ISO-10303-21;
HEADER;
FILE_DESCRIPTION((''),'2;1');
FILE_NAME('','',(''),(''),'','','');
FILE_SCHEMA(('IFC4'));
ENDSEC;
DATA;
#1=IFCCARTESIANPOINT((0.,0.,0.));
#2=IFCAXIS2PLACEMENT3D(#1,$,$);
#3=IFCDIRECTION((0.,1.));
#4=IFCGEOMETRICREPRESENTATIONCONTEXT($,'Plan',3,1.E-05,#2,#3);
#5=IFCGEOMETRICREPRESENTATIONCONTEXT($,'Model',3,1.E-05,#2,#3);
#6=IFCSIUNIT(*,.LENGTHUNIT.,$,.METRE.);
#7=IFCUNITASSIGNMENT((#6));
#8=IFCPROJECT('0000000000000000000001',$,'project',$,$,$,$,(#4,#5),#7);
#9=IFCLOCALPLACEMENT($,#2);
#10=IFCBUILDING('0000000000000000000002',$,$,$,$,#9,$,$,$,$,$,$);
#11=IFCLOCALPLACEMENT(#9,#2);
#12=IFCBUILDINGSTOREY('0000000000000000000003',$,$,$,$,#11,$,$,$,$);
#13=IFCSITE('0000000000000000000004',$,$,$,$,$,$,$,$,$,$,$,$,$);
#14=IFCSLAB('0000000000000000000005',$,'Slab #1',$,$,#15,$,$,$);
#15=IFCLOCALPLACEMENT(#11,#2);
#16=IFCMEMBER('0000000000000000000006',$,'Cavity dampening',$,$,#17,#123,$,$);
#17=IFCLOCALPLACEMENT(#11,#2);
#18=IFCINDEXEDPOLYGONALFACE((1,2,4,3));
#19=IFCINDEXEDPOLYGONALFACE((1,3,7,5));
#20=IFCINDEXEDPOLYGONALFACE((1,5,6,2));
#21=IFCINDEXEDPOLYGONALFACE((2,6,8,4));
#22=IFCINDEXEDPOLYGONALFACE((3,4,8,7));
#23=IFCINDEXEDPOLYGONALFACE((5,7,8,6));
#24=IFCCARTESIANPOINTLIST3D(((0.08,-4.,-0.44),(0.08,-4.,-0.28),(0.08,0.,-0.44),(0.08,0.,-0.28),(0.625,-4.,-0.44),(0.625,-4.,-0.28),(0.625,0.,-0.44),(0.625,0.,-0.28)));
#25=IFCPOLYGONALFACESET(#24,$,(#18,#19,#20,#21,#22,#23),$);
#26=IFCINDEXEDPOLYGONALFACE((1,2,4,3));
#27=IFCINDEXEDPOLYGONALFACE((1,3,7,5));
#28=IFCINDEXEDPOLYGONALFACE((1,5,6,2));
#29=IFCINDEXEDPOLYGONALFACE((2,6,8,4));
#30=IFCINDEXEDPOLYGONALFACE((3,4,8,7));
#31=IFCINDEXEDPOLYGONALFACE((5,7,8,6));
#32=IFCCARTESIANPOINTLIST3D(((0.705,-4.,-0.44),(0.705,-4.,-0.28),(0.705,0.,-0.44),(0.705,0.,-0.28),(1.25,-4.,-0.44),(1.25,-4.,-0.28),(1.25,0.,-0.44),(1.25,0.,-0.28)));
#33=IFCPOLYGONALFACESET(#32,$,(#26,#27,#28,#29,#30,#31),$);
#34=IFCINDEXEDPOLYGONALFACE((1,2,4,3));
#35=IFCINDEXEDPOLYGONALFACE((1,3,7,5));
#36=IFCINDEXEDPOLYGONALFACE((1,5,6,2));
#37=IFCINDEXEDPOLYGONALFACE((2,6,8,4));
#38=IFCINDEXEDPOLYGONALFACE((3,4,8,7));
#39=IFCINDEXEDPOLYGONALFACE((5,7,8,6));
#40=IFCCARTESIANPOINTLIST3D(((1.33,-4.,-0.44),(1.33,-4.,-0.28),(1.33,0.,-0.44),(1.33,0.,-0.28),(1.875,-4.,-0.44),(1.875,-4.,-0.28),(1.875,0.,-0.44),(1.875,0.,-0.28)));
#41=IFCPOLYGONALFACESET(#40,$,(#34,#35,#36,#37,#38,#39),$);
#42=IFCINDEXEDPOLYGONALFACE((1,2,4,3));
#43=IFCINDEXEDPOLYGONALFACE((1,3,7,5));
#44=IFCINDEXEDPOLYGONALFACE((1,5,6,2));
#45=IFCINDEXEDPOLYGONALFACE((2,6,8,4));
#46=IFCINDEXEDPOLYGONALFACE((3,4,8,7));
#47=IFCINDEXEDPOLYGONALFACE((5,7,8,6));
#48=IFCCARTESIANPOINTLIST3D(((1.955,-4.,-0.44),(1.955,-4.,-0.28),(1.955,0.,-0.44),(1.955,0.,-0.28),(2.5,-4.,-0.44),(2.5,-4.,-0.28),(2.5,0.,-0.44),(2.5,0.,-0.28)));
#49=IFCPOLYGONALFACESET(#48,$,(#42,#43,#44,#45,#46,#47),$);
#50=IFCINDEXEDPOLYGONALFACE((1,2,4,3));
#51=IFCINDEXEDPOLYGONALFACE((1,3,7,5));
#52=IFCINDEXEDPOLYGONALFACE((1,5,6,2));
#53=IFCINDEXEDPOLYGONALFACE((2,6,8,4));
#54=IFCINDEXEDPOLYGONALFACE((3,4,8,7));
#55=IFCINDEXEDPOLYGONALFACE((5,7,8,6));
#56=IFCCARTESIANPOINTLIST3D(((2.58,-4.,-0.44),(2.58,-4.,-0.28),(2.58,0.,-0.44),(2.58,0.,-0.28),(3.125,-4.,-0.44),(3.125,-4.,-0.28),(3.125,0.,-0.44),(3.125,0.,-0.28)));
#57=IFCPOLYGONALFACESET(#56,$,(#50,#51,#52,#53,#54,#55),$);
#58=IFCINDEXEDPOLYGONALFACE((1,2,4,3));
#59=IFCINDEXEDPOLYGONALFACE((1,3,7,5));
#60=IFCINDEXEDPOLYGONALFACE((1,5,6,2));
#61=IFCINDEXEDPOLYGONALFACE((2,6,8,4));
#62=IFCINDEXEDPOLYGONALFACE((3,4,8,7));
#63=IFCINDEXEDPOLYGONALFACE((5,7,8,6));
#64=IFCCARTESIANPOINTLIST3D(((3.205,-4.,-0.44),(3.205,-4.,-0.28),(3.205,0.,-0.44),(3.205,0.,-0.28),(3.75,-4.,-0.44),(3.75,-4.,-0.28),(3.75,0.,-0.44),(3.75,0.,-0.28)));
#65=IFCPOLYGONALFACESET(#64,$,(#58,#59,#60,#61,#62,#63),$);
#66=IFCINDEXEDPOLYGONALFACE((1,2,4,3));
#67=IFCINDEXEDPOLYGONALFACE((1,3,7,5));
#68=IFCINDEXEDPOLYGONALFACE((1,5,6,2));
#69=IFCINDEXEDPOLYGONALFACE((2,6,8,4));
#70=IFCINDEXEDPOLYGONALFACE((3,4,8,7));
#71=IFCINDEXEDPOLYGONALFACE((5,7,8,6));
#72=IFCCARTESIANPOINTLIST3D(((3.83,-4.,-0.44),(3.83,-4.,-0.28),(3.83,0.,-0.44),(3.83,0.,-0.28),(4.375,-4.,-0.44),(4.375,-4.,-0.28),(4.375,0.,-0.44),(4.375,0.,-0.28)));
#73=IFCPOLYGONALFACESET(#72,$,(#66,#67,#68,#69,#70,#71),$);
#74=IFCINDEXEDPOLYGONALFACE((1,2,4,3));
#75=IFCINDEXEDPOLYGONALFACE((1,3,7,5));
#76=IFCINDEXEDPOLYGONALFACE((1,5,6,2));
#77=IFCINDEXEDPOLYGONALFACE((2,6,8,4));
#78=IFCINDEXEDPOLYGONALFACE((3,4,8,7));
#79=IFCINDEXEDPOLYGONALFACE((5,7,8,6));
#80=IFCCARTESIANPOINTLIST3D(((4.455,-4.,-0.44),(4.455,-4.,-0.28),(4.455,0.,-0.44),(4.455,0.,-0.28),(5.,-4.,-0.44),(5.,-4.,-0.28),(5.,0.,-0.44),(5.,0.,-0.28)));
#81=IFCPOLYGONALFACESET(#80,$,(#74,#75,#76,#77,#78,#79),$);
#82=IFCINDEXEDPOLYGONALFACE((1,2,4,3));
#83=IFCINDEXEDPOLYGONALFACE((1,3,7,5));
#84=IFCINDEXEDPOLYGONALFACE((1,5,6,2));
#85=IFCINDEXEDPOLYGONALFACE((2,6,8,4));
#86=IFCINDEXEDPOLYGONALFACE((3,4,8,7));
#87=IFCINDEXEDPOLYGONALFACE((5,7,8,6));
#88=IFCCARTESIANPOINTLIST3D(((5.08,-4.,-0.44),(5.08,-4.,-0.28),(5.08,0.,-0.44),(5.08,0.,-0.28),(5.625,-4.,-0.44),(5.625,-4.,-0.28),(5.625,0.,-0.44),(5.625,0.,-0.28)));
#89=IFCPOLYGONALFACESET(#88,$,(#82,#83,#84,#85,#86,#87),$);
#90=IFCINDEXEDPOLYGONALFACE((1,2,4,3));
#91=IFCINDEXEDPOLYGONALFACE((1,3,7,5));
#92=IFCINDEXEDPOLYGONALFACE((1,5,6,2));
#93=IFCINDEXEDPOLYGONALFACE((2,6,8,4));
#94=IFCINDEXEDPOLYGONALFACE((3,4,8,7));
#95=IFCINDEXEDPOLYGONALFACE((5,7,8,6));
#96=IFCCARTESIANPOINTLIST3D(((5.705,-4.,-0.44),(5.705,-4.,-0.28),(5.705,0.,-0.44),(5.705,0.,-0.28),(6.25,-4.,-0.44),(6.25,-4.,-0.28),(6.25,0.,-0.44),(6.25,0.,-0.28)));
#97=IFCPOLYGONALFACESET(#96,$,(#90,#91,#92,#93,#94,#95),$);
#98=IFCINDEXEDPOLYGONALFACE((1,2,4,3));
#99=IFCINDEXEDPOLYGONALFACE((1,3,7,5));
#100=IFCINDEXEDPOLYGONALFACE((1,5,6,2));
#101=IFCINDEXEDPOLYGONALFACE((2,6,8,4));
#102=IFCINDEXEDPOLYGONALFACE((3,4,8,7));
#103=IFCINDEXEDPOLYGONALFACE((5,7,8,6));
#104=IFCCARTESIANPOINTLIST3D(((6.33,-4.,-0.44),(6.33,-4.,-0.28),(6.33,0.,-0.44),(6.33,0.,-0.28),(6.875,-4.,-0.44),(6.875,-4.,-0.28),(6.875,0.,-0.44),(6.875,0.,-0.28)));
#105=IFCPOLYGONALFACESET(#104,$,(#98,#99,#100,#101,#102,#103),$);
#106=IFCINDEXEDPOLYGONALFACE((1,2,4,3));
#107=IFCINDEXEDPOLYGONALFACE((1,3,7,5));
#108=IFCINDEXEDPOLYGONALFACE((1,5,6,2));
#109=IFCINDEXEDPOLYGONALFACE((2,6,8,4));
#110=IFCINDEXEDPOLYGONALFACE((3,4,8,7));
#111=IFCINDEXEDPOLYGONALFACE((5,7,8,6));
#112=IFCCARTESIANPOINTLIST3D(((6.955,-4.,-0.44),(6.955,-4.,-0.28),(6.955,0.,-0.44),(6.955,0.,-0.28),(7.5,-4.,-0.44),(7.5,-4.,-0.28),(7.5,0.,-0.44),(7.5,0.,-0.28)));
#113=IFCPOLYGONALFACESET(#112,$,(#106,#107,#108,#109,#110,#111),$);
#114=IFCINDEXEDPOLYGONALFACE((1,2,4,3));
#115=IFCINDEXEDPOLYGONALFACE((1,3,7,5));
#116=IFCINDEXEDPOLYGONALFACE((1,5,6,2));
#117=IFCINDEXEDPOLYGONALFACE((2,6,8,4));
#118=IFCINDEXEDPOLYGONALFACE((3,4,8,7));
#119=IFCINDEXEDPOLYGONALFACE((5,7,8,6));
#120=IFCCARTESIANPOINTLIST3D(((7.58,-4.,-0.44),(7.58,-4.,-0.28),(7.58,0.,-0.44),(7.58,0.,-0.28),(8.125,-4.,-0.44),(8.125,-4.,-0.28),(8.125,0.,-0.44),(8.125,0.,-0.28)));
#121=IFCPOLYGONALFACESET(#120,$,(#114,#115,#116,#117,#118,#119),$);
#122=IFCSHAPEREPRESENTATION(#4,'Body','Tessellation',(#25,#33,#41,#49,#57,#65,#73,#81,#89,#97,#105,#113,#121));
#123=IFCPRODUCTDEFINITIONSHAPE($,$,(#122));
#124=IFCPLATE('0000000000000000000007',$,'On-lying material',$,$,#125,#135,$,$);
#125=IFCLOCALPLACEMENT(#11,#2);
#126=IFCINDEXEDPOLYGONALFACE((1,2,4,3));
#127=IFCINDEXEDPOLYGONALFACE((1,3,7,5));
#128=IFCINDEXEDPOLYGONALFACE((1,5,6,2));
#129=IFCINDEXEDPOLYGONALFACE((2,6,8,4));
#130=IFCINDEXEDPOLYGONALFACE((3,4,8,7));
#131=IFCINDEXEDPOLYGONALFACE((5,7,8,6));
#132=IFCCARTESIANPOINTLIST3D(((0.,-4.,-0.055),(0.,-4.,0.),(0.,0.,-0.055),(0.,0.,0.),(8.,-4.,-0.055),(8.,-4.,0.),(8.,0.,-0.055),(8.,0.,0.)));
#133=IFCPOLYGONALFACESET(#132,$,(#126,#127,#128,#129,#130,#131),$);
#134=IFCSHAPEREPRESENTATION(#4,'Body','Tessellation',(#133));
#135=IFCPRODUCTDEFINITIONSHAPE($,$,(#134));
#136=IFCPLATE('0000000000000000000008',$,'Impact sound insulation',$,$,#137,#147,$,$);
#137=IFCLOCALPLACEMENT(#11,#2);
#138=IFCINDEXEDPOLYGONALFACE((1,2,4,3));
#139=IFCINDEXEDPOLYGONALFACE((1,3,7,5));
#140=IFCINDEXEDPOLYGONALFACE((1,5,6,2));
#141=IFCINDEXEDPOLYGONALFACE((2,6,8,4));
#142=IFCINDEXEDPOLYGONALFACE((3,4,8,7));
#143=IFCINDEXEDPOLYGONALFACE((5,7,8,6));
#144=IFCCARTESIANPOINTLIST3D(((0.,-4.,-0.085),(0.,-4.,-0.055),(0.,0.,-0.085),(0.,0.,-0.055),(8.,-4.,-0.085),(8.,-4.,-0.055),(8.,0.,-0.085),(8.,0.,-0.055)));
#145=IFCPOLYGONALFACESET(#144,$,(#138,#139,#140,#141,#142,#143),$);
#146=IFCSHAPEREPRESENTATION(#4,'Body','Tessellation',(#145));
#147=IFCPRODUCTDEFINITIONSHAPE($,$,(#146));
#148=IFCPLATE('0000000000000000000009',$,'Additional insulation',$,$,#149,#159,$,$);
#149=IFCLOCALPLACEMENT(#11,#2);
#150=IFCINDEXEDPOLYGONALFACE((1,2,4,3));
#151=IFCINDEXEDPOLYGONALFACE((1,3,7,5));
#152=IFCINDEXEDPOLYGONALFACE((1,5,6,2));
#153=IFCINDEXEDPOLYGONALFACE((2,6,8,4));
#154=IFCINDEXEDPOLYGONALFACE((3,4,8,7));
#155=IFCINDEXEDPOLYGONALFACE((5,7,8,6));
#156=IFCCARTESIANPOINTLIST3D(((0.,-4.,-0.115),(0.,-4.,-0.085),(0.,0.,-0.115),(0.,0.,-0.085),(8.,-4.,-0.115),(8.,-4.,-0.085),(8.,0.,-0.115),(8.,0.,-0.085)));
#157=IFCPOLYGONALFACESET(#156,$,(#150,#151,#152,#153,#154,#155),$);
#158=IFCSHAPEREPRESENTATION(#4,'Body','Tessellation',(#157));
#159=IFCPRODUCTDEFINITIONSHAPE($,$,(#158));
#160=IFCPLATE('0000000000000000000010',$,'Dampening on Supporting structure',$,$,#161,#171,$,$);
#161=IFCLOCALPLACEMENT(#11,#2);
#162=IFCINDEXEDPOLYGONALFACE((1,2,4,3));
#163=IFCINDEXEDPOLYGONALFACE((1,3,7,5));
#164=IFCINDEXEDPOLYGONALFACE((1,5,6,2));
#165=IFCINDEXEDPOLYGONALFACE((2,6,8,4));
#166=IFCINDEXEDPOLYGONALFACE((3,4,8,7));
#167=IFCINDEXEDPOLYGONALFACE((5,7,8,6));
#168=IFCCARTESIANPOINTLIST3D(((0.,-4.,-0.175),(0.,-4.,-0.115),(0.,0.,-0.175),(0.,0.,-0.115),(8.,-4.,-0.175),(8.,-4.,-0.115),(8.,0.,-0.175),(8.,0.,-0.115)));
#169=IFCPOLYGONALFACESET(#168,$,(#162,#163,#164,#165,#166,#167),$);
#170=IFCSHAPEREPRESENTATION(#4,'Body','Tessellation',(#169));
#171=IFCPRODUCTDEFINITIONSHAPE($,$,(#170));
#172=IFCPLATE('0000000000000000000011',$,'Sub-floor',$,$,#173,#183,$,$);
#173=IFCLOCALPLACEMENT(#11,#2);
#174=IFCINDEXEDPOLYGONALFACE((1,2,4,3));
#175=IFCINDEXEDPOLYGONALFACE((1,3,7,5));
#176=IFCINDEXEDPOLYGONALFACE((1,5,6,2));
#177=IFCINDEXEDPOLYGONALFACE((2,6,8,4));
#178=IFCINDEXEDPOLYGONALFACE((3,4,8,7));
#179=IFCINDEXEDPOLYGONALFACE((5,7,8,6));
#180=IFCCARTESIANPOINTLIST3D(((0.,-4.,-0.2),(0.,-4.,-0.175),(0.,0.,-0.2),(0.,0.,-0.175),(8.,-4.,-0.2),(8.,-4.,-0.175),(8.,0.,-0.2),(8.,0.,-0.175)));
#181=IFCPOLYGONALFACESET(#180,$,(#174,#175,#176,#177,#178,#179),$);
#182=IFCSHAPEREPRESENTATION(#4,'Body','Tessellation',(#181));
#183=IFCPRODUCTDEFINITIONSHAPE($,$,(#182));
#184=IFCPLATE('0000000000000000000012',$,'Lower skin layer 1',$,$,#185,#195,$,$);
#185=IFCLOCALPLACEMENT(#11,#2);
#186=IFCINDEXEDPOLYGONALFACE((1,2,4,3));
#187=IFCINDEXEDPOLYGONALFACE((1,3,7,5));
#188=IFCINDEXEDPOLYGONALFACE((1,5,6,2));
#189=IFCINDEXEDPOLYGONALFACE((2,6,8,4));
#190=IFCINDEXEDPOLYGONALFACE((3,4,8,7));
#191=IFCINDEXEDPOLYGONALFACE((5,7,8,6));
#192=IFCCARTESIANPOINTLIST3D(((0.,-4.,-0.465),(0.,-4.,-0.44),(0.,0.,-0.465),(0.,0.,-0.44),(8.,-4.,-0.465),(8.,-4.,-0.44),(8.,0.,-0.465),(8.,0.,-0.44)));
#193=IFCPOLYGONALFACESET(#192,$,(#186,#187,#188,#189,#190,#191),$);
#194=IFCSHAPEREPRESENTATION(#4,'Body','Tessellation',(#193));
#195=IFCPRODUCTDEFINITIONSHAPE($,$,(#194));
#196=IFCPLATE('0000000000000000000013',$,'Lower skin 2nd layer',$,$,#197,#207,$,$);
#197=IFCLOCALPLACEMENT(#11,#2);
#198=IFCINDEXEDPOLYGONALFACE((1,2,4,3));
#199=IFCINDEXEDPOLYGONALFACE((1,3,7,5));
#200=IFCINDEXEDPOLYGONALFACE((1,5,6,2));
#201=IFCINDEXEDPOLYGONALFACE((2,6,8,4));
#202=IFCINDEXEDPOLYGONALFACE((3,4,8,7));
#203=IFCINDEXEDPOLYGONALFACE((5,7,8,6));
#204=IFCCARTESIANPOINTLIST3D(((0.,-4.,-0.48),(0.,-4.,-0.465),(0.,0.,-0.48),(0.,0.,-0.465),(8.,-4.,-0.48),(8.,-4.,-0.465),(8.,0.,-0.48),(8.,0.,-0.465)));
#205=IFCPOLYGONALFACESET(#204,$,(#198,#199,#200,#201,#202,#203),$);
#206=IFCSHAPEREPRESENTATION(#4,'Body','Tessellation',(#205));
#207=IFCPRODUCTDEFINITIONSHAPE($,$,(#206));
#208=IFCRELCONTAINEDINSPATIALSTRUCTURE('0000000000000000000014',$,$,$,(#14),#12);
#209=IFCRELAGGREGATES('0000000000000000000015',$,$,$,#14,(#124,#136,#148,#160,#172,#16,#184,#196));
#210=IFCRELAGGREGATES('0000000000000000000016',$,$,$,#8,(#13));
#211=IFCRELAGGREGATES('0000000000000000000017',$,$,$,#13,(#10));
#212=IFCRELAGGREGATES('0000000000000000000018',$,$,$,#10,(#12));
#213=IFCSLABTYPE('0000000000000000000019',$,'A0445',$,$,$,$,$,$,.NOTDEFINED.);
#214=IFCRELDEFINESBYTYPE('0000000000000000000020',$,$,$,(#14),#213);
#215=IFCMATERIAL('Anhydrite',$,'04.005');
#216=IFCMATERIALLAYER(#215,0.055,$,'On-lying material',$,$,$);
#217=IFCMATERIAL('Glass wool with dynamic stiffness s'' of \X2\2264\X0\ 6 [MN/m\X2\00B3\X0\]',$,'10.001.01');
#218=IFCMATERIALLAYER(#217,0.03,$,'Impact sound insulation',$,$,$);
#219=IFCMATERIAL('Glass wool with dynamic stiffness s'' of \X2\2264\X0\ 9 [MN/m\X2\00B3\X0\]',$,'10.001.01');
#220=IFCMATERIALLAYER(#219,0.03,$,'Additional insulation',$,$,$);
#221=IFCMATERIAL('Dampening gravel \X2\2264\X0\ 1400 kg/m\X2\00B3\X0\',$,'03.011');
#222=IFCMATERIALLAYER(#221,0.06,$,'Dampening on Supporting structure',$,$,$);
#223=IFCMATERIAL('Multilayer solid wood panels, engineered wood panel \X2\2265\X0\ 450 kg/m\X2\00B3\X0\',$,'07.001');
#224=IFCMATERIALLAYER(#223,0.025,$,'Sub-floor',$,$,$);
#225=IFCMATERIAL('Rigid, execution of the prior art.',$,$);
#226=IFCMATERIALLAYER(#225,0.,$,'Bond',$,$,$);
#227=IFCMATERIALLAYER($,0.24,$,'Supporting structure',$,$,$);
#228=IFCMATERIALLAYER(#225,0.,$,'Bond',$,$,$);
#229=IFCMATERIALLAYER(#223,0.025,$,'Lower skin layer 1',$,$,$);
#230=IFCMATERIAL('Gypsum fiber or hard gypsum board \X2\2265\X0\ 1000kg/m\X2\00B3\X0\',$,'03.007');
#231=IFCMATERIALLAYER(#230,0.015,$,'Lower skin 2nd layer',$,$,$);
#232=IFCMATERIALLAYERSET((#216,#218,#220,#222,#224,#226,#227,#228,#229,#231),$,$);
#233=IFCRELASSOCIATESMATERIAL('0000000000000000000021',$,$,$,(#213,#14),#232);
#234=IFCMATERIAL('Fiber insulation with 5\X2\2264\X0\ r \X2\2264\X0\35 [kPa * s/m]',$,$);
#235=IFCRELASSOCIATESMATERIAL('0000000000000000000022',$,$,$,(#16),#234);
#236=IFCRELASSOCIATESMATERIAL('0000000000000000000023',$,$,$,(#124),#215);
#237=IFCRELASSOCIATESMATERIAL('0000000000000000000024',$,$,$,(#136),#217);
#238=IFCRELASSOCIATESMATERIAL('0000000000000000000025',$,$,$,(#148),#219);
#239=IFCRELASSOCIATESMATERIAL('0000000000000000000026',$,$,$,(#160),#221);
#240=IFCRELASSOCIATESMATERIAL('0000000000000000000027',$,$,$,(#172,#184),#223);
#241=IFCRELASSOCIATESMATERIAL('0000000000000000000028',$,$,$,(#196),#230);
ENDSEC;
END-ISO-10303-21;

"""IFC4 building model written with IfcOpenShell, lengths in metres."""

from ifc_helpers import new_model, si_unit, direction, frame, frame_2d, origin, origin_with_axes, place, context, project, spatial, rectangle, extrude, material, layer, layer_set, type_object, element, aggregate, save


model = new_model("IFC4")

# Units and contexts
plan_context = context("Plan", 3, precision=1e-05, world=origin(), true_north=direction((0.0, 1.0)))
model_context = context("Model", 3, precision=1e-05, world=origin(), true_north=direction((0.0, 1.0)))
ifc_project = project(units=[si_unit("LENGTHUNIT", "METRE")], contexts=[plan_context, model_context])

# Site, building, storey
site = spatial("IfcSite", under=ifc_project)
building_placement = place(None, origin())
building = spatial("IfcBuilding", under=site, at=building_placement)
storey_placement = place(building_placement, origin())
storey = spatial("IfcBuildingStorey", under=building, at=storey_placement)

# Slab, member, plates
ifc_material_1 = material(Name="Anhydrite", Category="04.005")
ifc_layer_1 = layer(ifc_material_1, 0.055, Name="On-lying material")
ifc_material_2 = material(Name="Glass wool with dynamic stiffness s' of ≤ 6 [MN/m³]", Category="10.001.01")
ifc_layer_2 = layer(ifc_material_2, 0.03, Name="Impact sound insulation")
ifc_material_3 = material(Name="Glass wool with dynamic stiffness s' of ≤ 9 [MN/m³]", Category="10.001.01")
ifc_layer_3 = layer(ifc_material_3, 0.03, Name="Additional insulation")
ifc_material_4 = material(Name="Dampening gravel ≤ 1400 kg/m³", Category="03.011")
ifc_layer_4 = layer(ifc_material_4, 0.06, Name="Dampening on Supporting structure")
ifc_material_5 = material(Name="Multilayer solid wood panels, engineered wood panel ≥ 450 kg/m³", Category="07.001")
ifc_layer_5 = layer(ifc_material_5, 0.025, Name="Sub-floor")
ifc_material_6 = material(Name="Rigid, execution of the prior art.")
ifc_layer_6 = layer(ifc_material_6, 0.0, Name="Bond")
ifc_layer_7 = layer(None, 0.24, Name="Supporting structure")
ifc_layer_8 = layer(ifc_material_6, 0.0, Name="Bond")
ifc_layer_9 = layer(ifc_material_5, 0.025, Name="Lower skin layer 1")
ifc_material_7 = material(Name="Gypsum fiber or hard gypsum board ≥ 1000kg/m³", Category="03.007")
ifc_layer_10 = layer(ifc_material_7, 0.015, Name="Lower skin 2nd layer")
ifc_layer_set = layer_set([ifc_layer_1, ifc_layer_2, ifc_layer_3, ifc_layer_4, ifc_layer_5, ifc_layer_6, ifc_layer_7, ifc_layer_8, ifc_layer_9, ifc_layer_10])
slab_type = type_object("IfcSlabType", Name="A0445", PredefinedType="NOTDEFINED", material=ifc_layer_set)
slab_placement = place(None, frame((0.0, 0.0, 0.0), z_axis=(0.0, 0.0, -1.0), x_axis=(1.0, 0.0, 0.0)))
slab = element("IfcSlab", 1, at=slab_placement, inside=storey, type_object=slab_type, material=ifc_layer_set, Name="Slab #1")
ifc_material_8 = material(Name="Fiber insulation with 5≤ r ≤35 [kPa * s/m]")
member_1_placement = place(slab_placement, origin())
member_1 = element("IfcMember", 2, at=member_1_placement, material=ifc_material_8, Name="Cavity dampening", context=plan_context, shape_type="SweptSolid", body=[
    extrude(rectangle(XDim=0.545, YDim=0.16, at=frame_2d((0.2725, 0.08), x_axis=(1.0, 0.0))), frame((0.08, 4.0, 0.28), z_axis=(0.0, -1.0, 0.0), x_axis=(1.0, 0.0, 0.0)), (0.0, 0.0, 1.0), 4.0),
    extrude(rectangle(XDim=0.545, YDim=0.16, at=frame_2d((0.2725, 0.08), x_axis=(1.0, 0.0))), frame((0.705, 4.0, 0.28), z_axis=(0.0, -1.0, 0.0), x_axis=(1.0, 0.0, 0.0)), (0.0, 0.0, 1.0), 4.0),
    extrude(rectangle(XDim=0.545, YDim=0.16, at=frame_2d((0.2725, 0.08), x_axis=(1.0, 0.0))), frame((1.33, 4.0, 0.28), z_axis=(0.0, -1.0, 0.0), x_axis=(1.0, 0.0, 0.0)), (0.0, 0.0, 1.0), 4.0),
    extrude(rectangle(XDim=0.545, YDim=0.16, at=frame_2d((0.2725, 0.08), x_axis=(1.0, 0.0))), frame((1.955, 4.0, 0.28), z_axis=(0.0, -1.0, 0.0), x_axis=(1.0, 0.0, 0.0)), (0.0, 0.0, 1.0), 4.0),
    extrude(rectangle(XDim=0.545, YDim=0.16, at=frame_2d((0.2725, 0.08), x_axis=(1.0, 0.0))), frame((2.58, 4.0, 0.28), z_axis=(0.0, -1.0, 0.0), x_axis=(1.0, 0.0, 0.0)), (0.0, 0.0, 1.0), 4.0),
    extrude(rectangle(XDim=0.545, YDim=0.16, at=frame_2d((0.2725, 0.08), x_axis=(1.0, 0.0))), frame((3.205, 4.0, 0.28), z_axis=(0.0, -1.0, 0.0), x_axis=(1.0, 0.0, 0.0)), (0.0, 0.0, 1.0), 4.0),
    extrude(rectangle(XDim=0.545, YDim=0.16, at=frame_2d((0.2725, 0.08), x_axis=(1.0, 0.0))), frame((3.83, 4.0, 0.28), z_axis=(0.0, -1.0, 0.0), x_axis=(1.0, 0.0, 0.0)), (0.0, 0.0, 1.0), 4.0),
    extrude(rectangle(XDim=0.545, YDim=0.16, at=frame_2d((0.2725, 0.08), x_axis=(1.0, 0.0))), frame((4.455, 4.0, 0.28), z_axis=(0.0, -1.0, 0.0), x_axis=(1.0, 0.0, 0.0)), (0.0, 0.0, 1.0), 4.0),
    extrude(rectangle(XDim=0.545, YDim=0.16, at=frame_2d((0.2725, 0.08), x_axis=(1.0, 0.0))), frame((5.08, 4.0, 0.28), z_axis=(0.0, -1.0, 0.0), x_axis=(1.0, 0.0, 0.0)), (0.0, 0.0, 1.0), 4.0),
    extrude(rectangle(XDim=0.545, YDim=0.16, at=frame_2d((0.2725, 0.08), x_axis=(1.0, 0.0))), frame((5.705, 4.0, 0.28), z_axis=(0.0, -1.0, 0.0), x_axis=(1.0, 0.0, 0.0)), (0.0, 0.0, 1.0), 4.0),
    extrude(rectangle(XDim=0.545, YDim=0.16, at=frame_2d((0.2725, 0.08), x_axis=(1.0, 0.0))), frame((6.33, 4.0, 0.28), z_axis=(0.0, -1.0, 0.0), x_axis=(1.0, 0.0, 0.0)), (0.0, 0.0, 1.0), 4.0),
    extrude(rectangle(XDim=0.545, YDim=0.16, at=frame_2d((0.2725, 0.08), x_axis=(1.0, 0.0))), frame((6.955, 4.0, 0.28), z_axis=(0.0, -1.0, 0.0), x_axis=(1.0, 0.0, 0.0)), (0.0, 0.0, 1.0), 4.0),
    extrude(rectangle(XDim=0.545, YDim=0.16, at=frame_2d((0.2725, 0.08), x_axis=(1.0, 0.0))), frame((7.58, 4.0, 0.28), z_axis=(0.0, -1.0, 0.0), x_axis=(1.0, 0.0, 0.0)), (0.0, 0.0, 1.0), 4.0),
])
plate_1_placement = place(slab_placement, origin())
plate_1 = element("IfcPlate", 3, at=plate_1_placement, material=ifc_material_1, Name="On-lying material", context=plan_context, shape_type="SweptSolid", body=[
    extrude(rectangle(XDim=8.0, YDim=4.0, at=frame_2d((4.0, 2.0), x_axis=(1.0, 0.0))), origin_with_axes(), (0.0, 0.0, 1.0), 0.055),
])
plate_2_placement = place(slab_placement, origin())
plate_2 = element("IfcPlate", 4, at=plate_2_placement, material=ifc_material_2, Name="Impact sound insulation", context=plan_context, shape_type="SweptSolid", body=[
    extrude(rectangle(XDim=8.0, YDim=4.0, at=frame_2d((4.0, 2.0), x_axis=(1.0, 0.0))), frame((0.0, 0.0, 0.055), z_axis=(0.0, 0.0, 1.0), x_axis=(1.0, 0.0, 0.0)), (0.0, 0.0, 1.0), 0.03),
])
plate_3_placement = place(slab_placement, origin())
plate_3 = element("IfcPlate", 5, at=plate_3_placement, material=ifc_material_3, Name="Additional insulation", context=plan_context, shape_type="SweptSolid", body=[
    extrude(rectangle(XDim=8.0, YDim=4.0, at=frame_2d((4.0, 2.0), x_axis=(1.0, 0.0))), frame((0.0, 0.0, 0.085), z_axis=(0.0, 0.0, 1.0), x_axis=(1.0, 0.0, 0.0)), (0.0, 0.0, 1.0), 0.03),
])
plate_4_placement = place(slab_placement, origin())
plate_4 = element("IfcPlate", 6, at=plate_4_placement, material=ifc_material_4, Name="Dampening on Supporting structure", context=plan_context, shape_type="SweptSolid", body=[
    extrude(rectangle(XDim=8.0, YDim=4.0, at=frame_2d((4.0, 2.0), x_axis=(1.0, 0.0))), frame((0.0, 0.0, 0.115), z_axis=(0.0, 0.0, 1.0), x_axis=(1.0, 0.0, 0.0)), (0.0, 0.0, 1.0), 0.06),
])
plate_5_placement = place(slab_placement, origin())
plate_5 = element("IfcPlate", 7, at=plate_5_placement, material=ifc_material_5, Name="Sub-floor", context=plan_context, shape_type="SweptSolid", body=[
    extrude(rectangle(XDim=8.0, YDim=4.0, at=frame_2d((4.0, 2.0), x_axis=(1.0, 0.0))), frame((0.0, 0.0, 0.175), z_axis=(0.0, 0.0, 1.0), x_axis=(1.0, 0.0, 0.0)), (0.0, 0.0, 1.0), 0.025),
])
plate_6_placement = place(slab_placement, origin())
plate_6 = element("IfcPlate", 8, at=plate_6_placement, material=ifc_material_5, Name="Lower skin layer 1", context=plan_context, shape_type="SweptSolid", body=[
    extrude(rectangle(XDim=8.0, YDim=4.0, at=frame_2d((4.0, 2.0), x_axis=(1.0, 0.0))), frame((0.0, 0.0, 0.44), z_axis=(0.0, 0.0, 1.0), x_axis=(1.0, 0.0, 0.0)), (0.0, 0.0, 1.0), 0.025),
])
plate_7_placement = place(slab_placement, origin())
plate_7 = element("IfcPlate", 9, at=plate_7_placement, material=ifc_material_7, Name="Lower skin 2nd layer", context=plan_context, shape_type="SweptSolid", body=[
    extrude(rectangle(XDim=8.0, YDim=4.0, at=frame_2d((4.0, 2.0), x_axis=(1.0, 0.0))), frame((0.0, 0.0, 0.465), z_axis=(0.0, 0.0, 1.0), x_axis=(1.0, 0.0, 0.0)), (0.0, 0.0, 1.0), 0.015),
])
aggregate(slab, [plate_1, plate_2, plate_3, plate_4, plate_5, member_1, plate_6, plate_7])

save(model, "model.ifc")
